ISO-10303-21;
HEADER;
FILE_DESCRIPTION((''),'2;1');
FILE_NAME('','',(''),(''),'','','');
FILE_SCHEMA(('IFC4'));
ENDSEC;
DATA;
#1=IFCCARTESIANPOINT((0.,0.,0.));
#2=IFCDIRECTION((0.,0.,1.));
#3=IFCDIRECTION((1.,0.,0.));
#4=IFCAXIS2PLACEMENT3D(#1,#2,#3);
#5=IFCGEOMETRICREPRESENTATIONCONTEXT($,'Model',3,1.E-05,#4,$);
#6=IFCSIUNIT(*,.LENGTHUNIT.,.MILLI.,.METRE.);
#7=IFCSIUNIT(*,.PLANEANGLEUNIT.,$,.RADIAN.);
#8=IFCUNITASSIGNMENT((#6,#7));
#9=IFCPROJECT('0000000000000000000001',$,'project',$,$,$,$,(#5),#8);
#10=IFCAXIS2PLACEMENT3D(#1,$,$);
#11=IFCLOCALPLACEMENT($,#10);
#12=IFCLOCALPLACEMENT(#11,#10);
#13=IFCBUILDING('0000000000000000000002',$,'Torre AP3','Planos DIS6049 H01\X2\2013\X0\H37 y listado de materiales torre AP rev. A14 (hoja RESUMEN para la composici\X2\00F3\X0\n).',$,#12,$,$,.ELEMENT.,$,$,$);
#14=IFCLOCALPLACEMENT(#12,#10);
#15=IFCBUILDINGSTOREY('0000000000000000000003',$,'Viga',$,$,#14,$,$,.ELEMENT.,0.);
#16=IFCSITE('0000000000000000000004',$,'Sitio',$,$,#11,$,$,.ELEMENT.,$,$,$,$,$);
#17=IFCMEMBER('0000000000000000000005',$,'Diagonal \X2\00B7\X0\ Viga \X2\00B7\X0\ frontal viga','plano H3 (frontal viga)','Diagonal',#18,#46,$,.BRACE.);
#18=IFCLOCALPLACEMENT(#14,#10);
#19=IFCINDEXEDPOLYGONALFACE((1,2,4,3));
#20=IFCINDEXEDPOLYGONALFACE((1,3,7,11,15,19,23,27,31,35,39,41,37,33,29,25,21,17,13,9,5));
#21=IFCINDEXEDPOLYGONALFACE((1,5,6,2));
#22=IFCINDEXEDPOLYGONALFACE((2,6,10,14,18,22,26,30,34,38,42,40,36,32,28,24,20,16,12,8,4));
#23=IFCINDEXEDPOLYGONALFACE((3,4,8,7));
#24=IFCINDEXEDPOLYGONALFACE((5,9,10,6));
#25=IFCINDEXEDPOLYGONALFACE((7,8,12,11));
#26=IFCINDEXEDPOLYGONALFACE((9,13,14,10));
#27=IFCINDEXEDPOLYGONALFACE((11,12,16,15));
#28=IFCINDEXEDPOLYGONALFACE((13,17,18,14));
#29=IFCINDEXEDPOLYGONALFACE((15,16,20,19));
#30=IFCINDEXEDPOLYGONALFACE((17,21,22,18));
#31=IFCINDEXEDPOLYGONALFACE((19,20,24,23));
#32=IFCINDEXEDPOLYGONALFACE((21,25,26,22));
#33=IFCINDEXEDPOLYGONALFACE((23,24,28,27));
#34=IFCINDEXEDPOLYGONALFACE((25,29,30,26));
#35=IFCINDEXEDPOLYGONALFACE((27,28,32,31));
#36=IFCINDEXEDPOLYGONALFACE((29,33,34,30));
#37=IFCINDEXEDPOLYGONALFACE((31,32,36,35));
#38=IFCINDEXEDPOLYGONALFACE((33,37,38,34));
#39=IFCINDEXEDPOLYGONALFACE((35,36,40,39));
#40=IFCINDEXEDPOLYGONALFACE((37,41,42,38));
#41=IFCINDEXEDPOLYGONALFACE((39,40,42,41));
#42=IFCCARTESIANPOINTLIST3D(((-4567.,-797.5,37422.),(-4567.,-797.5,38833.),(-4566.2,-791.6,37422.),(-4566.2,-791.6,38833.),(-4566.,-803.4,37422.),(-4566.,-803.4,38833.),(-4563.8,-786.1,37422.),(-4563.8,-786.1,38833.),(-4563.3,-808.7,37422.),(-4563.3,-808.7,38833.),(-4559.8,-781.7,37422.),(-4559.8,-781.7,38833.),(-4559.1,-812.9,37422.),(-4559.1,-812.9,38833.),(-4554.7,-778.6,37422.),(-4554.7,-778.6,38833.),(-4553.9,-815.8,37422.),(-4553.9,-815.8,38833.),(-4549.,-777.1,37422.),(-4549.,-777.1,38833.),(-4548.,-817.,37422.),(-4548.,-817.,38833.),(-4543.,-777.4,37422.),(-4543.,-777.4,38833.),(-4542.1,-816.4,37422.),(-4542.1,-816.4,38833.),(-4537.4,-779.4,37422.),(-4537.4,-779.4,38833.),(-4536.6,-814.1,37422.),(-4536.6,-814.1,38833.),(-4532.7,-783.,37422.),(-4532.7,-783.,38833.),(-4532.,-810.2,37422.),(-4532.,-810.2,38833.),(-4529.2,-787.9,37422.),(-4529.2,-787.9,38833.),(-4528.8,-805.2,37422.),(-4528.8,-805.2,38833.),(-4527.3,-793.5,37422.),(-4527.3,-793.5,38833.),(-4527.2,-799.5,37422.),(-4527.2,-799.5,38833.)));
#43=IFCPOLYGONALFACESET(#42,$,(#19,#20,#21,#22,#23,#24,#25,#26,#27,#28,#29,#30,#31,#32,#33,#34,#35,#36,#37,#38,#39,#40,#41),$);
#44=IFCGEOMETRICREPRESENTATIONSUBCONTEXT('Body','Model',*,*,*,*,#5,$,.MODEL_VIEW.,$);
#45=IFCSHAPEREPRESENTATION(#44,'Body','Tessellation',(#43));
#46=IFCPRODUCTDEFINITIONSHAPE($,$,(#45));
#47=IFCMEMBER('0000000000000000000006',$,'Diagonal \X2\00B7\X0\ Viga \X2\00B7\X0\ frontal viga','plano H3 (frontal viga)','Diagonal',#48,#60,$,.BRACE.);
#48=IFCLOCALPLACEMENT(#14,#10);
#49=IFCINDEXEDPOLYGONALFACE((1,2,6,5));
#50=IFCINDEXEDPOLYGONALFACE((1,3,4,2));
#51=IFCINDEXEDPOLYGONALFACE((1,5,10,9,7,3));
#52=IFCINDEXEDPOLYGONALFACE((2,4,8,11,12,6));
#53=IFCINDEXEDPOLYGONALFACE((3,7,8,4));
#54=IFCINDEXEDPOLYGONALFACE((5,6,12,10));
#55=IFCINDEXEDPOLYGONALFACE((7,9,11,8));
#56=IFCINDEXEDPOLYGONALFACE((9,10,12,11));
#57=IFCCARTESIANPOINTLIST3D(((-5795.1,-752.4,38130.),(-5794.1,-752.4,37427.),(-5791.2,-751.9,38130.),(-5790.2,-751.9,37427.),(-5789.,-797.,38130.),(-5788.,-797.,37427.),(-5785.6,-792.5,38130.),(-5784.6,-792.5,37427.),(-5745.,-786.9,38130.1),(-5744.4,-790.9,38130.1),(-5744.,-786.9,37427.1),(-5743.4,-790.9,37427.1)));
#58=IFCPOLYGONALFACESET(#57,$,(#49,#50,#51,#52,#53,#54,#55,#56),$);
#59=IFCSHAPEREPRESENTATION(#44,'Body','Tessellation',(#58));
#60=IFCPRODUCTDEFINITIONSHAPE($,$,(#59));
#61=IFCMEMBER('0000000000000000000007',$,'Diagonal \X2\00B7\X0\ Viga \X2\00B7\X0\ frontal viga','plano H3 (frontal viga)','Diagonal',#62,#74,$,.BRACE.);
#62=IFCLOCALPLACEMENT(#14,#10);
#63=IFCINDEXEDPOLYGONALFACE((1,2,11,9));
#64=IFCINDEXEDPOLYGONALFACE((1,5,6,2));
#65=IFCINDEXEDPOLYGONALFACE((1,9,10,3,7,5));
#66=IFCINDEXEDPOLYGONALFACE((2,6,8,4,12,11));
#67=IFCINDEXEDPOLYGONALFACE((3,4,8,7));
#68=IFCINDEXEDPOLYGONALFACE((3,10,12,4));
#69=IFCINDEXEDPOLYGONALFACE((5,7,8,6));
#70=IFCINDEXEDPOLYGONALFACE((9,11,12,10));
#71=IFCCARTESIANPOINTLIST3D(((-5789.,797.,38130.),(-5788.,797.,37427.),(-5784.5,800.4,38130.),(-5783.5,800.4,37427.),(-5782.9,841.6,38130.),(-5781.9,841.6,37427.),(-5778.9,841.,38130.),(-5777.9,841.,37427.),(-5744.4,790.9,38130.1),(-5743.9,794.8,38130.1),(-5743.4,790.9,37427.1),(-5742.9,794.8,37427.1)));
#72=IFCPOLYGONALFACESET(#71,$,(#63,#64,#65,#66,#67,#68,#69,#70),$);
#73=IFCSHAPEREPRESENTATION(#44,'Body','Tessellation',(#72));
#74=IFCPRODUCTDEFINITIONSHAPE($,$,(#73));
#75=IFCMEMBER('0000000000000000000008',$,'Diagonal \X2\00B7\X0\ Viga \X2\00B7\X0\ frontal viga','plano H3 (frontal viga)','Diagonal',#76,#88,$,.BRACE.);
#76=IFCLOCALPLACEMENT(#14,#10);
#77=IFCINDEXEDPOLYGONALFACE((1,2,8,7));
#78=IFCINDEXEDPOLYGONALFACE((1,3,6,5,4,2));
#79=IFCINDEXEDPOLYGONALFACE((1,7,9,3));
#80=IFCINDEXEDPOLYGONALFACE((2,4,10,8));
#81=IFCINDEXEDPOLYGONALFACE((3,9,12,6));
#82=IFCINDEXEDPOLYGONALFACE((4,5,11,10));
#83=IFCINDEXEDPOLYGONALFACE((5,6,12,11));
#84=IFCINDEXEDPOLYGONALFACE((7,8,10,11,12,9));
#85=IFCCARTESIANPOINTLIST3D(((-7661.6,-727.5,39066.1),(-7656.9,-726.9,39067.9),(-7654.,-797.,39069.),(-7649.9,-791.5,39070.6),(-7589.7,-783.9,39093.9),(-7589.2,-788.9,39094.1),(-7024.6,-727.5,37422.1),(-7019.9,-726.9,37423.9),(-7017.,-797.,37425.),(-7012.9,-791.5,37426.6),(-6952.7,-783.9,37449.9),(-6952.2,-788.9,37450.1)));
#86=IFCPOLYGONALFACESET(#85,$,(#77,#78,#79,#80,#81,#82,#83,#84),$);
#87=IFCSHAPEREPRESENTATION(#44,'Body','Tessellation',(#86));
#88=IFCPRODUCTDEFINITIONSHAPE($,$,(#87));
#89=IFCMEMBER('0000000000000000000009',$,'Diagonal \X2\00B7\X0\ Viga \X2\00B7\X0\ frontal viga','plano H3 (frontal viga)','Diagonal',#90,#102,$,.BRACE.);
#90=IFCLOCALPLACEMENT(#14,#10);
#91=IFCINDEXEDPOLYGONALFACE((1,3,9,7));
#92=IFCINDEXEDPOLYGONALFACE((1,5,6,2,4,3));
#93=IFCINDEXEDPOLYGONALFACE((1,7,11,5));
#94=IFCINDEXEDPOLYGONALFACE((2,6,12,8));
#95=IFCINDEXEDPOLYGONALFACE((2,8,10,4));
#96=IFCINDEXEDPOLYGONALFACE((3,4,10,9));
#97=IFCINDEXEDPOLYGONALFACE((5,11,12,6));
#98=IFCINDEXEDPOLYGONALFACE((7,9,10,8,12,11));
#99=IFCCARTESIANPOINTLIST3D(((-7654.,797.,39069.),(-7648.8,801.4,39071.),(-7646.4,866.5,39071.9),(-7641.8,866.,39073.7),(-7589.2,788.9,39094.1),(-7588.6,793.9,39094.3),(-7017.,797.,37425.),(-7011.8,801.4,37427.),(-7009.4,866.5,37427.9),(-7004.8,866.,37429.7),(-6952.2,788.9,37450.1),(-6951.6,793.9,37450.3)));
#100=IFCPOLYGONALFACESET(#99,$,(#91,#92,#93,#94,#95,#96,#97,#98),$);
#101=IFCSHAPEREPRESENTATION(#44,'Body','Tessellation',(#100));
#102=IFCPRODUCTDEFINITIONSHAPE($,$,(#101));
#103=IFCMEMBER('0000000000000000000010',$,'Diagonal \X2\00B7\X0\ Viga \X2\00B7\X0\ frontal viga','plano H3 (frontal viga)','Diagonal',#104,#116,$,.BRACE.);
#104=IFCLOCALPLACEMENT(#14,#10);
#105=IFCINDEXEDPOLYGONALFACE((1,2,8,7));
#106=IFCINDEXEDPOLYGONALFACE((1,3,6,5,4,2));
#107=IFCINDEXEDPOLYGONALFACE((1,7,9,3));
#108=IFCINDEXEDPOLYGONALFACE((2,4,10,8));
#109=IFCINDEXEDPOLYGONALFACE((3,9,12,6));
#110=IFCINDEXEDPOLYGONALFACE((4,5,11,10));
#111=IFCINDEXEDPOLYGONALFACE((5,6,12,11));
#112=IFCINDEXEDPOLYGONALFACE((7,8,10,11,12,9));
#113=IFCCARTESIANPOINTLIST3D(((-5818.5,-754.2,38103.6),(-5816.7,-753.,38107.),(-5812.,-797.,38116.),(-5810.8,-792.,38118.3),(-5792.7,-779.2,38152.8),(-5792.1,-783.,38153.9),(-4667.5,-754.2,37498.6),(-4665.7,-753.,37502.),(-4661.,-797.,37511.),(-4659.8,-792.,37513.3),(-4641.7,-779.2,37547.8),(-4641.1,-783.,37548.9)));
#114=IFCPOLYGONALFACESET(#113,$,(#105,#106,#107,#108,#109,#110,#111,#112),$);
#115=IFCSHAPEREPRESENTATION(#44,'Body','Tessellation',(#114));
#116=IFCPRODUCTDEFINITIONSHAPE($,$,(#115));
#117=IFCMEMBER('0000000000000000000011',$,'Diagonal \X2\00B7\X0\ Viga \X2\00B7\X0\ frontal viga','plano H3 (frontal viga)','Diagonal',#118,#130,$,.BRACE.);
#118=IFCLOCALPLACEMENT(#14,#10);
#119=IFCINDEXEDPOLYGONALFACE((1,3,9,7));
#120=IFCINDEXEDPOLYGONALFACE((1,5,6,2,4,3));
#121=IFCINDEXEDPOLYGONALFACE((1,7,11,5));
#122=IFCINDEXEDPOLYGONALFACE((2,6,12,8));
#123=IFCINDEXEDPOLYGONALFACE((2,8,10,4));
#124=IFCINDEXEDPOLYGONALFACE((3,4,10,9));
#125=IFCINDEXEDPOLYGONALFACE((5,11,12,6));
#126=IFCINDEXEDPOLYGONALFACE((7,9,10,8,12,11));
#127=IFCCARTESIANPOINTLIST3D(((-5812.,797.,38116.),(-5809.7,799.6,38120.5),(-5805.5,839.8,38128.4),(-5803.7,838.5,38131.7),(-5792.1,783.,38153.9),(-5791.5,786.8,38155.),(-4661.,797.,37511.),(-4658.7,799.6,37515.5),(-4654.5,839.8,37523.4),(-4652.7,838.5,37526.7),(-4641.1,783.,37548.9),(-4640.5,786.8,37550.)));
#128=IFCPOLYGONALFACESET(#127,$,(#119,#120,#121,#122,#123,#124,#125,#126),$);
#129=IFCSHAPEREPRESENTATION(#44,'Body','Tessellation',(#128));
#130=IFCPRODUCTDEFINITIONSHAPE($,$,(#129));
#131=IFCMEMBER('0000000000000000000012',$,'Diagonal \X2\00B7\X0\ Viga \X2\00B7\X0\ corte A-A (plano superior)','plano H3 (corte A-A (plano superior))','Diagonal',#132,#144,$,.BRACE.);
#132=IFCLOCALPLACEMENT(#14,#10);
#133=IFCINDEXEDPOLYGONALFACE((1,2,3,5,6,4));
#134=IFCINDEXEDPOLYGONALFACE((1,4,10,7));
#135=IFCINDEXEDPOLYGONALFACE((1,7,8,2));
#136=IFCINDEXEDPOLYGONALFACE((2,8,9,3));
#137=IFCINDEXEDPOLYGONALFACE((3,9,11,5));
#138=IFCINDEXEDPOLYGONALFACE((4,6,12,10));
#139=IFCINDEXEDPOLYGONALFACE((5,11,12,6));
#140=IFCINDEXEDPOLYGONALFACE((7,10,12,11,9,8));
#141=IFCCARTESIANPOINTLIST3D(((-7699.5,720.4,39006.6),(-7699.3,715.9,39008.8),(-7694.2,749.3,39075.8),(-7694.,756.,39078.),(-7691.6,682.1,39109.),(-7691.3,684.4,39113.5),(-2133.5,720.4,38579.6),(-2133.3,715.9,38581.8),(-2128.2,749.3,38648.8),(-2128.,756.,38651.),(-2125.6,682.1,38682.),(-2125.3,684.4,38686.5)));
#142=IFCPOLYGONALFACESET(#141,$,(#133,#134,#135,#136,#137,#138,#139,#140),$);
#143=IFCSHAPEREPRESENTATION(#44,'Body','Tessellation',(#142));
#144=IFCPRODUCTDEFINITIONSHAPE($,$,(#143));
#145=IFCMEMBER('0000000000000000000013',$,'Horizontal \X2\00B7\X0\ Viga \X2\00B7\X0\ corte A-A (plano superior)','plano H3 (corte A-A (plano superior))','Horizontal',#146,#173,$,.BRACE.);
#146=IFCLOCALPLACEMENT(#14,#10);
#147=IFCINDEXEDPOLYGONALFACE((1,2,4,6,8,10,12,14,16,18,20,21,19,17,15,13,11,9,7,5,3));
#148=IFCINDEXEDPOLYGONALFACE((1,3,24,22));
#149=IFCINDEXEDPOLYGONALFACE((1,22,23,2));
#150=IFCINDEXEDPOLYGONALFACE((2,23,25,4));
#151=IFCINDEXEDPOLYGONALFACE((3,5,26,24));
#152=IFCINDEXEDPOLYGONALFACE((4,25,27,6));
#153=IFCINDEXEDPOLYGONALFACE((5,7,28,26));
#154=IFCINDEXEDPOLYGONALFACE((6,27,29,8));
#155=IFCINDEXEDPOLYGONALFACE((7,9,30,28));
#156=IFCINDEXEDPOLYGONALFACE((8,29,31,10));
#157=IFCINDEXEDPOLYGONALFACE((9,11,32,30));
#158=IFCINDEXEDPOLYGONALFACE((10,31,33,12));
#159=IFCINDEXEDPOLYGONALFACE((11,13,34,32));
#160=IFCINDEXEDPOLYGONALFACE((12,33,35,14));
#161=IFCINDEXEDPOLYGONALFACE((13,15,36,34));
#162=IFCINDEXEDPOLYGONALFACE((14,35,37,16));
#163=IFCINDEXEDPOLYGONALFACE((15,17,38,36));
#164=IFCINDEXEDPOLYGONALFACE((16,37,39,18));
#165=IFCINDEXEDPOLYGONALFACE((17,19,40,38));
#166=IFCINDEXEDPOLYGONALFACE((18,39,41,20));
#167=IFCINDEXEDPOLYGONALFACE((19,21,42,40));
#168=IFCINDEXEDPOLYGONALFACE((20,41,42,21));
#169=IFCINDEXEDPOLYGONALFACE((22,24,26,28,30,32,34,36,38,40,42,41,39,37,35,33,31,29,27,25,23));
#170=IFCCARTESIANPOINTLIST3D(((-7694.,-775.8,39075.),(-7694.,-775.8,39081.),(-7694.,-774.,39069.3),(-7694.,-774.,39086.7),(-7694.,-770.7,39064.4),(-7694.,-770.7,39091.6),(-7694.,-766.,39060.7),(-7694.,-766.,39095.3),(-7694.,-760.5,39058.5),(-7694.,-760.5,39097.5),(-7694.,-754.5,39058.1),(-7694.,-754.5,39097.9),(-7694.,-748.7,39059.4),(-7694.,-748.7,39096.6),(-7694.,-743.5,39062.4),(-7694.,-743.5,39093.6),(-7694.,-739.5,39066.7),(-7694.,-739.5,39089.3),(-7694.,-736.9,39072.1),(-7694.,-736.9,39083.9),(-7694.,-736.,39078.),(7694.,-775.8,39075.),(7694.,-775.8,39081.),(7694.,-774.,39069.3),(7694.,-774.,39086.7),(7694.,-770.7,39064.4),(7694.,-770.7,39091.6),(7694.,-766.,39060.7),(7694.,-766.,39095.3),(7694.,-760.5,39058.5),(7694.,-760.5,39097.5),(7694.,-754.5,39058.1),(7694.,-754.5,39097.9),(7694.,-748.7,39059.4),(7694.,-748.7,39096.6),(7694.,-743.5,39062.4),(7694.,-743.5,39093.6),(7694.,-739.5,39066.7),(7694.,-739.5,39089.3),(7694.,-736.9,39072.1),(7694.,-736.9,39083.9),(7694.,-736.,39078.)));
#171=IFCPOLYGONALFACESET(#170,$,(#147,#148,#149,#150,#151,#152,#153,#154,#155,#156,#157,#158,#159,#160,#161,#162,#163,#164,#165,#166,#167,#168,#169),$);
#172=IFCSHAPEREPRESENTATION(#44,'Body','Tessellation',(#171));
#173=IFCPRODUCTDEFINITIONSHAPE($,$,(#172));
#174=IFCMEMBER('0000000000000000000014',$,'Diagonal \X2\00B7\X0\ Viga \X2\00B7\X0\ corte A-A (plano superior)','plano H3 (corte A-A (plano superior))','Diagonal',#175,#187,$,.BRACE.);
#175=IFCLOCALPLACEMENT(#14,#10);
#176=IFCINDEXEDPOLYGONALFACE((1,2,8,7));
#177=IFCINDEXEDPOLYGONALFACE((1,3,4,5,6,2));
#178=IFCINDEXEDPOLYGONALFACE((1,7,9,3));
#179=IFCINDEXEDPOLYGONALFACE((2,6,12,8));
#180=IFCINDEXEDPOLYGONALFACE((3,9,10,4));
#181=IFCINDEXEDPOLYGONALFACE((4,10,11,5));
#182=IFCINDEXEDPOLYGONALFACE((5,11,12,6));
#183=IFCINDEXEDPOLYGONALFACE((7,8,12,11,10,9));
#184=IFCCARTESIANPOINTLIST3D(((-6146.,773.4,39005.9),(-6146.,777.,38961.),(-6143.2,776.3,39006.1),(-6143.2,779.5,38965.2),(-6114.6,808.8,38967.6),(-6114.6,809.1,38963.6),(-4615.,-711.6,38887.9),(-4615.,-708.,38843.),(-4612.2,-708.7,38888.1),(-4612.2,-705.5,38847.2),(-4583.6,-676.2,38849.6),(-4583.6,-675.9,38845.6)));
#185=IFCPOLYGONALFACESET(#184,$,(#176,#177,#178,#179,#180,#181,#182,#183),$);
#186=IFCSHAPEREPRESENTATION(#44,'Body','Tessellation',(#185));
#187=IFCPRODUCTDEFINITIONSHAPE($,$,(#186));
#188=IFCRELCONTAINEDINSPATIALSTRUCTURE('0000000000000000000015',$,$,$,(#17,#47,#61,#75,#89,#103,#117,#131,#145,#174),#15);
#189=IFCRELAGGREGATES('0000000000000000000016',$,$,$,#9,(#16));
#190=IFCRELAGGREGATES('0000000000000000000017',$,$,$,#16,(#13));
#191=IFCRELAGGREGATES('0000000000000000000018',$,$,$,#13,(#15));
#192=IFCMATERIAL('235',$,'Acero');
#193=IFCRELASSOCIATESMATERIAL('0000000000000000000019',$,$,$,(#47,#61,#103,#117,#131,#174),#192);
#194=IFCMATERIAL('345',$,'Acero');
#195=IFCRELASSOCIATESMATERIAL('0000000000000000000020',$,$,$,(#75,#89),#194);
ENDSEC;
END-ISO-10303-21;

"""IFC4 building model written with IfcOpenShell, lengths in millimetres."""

from ifc_helpers import new_model, si_unit, frame, frame_2d, origin, origin_with_axes, place, context, subcontext, project, spatial, circle, l_section, extrude, material, element, save


model = new_model("IFC4")

# Units and contexts
model_context = context("Model", 3, precision=1e-05, world=origin_with_axes())
body_context = subcontext(model_context, "Body", "Model", "MODEL_VIEW")
ifc_project = project(units=[si_unit("LENGTHUNIT", "METRE", prefix="MILLI"), si_unit("PLANEANGLEUNIT", "RADIAN")], contexts=[model_context])

# Site, building, storey
site_placement = place(None, origin())
site = spatial("IfcSite", under=ifc_project, at=site_placement, Name="Sitio", CompositionType="ELEMENT")
building_placement = place(site_placement, origin())
building = spatial("IfcBuilding", under=site, at=building_placement, Name="Torre AP3", Description="Planos DIS6049 H01–H37 y listado de materiales torre AP rev. A14 (hoja RESUMEN para la composición).", CompositionType="ELEMENT")
storey_placement = place(building_placement, origin())
storey = spatial("IfcBuildingStorey", under=building, at=storey_placement, Name="Viga", CompositionType="ELEMENT", Elevation=0.0)

# Members
ifc_material_1 = material(Name="345", Category="Acero")
member_1_placement = place(storey_placement, frame((-4547.0, -797.0, 37422.0), z_axis=(0.0, 0.0, 1.0), x_axis=(0.984984, 0.172648, 0.0)))
element("IfcMember", 1, at=member_1_placement, inside=storey, Name="Diagonal · Viga · frontal viga", Description="plano H3 (frontal viga)", ObjectType="Diagonal", PredefinedType="BRACE", context=body_context, shape_type="SweptSolid", body=[
    extrude(circle(Radius=20.0), None, (0.0, 0.0, 1.0), 1411.0),
])
ifc_material_2 = material(Name="235", Category="Acero")
for number, where, z_axis, x_axis, name in (
    (2, (-5788.0, -797.0, 37427.0), (-0.001422, 0.0, 0.999999), (0.990653, 0.1364, 0.001409), "Diagonal · Viga · frontal viga"),
    (3, (-5788.0, 797.0, 37427.0), (-0.001422, 0.0, 0.999999), (0.990653, -0.1364, 0.001409), "Diagonal · Viga · frontal viga"),
):
    element("IfcMember", number, at=place(storey_placement, frame(where, z_axis=z_axis, x_axis=x_axis)), inside=storey, material=ifc_material_2, Name=name, Description="plano H3 (frontal viga)", ObjectType="Diagonal", PredefinedType="BRACE", context=body_context, shape_type="SweptSolid", body=[
        extrude(l_section(Depth=45.0, Width=45.0, Thickness=4.0, at=frame_2d((22.5, 22.5))), None, (0.0, 0.0, 1.0), 703.0),
    ])
for number, where, z_axis, x_axis, name in (
    (4, (-7017.0, -797.0, 37425.0), (-0.361296, 0.0, 0.932451), (0.926185, 0.115738, 0.358868), "Diagonal · Viga · frontal viga"),
    (5, (-7017.0, 797.0, 37425.0), (-0.361296, 0.0, 0.932451), (0.926185, -0.115738, 0.358868), "Diagonal · Viga · frontal viga"),
):
    element("IfcMember", number, at=place(storey_placement, frame(where, z_axis=z_axis, x_axis=x_axis)), inside=storey, material=ifc_material_1, Name=name, Description="plano H3 (frontal viga)", ObjectType="Diagonal", PredefinedType="BRACE", context=body_context, shape_type="SweptSolid", body=[
        extrude(l_section(Depth=70.0, Width=70.0, Thickness=5.0, at=frame_2d((35.0, 35.0))), None, (0.0, 0.0, 1.0), 1763.1),
    ])
for number, where, z_axis, x_axis, name in (
    (6, (-4661.0, -797.0, 37511.0), (-0.885168, 0.0, 0.465271), (0.442212, 0.310911, 0.841299), "Diagonal · Viga · frontal viga"),
    (7, (-4661.0, 797.0, 37511.0), (-0.885168, 0.0, 0.465271), (0.442212, -0.310911, 0.841299), "Diagonal · Viga · frontal viga"),
):
    element("IfcMember", number, at=place(storey_placement, frame(where, z_axis=z_axis, x_axis=x_axis)), inside=storey, material=ifc_material_2, Name=name, Description="plano H3 (frontal viga)", ObjectType="Diagonal", PredefinedType="BRACE", context=body_context, shape_type="SweptSolid", body=[
        extrude(l_section(Depth=45.0, Width=45.0, Thickness=4.0, at=frame_2d((22.5, 22.5))), None, (0.0, 0.0, 1.0), 1300.3),
    ])
member_2_placement = place(storey_placement, frame((-7694.0, 756.0, 39078.0), z_axis=(0.99707, 0.0, -0.076491), x_axis=(0.034037, -0.895539, 0.443679)))
element("IfcMember", 8, at=member_2_placement, inside=storey, material=ifc_material_2, Name="Diagonal · Viga · corte A-A (plano superior)", Description="plano H3 (corte A-A (plano superior))", ObjectType="Diagonal", PredefinedType="BRACE", context=body_context, shape_type="SweptSolid", body=[
    extrude(l_section(Depth=80.0, Width=80.0, Thickness=5.0, at=frame_2d((40.0, 40.0))), None, (0.0, 0.0, 1.0), 5582.4),
])
member_3_placement = place(storey_placement, frame((-7694.0, -756.0, 39078.0), z_axis=(1.0, 0.0, 0.0), x_axis=(0.0, 1.0, 0.0)))
element("IfcMember", 9, at=member_3_placement, inside=storey, Name="Horizontal · Viga · corte A-A (plano superior)", Description="plano H3 (corte A-A (plano superior))", ObjectType="Horizontal", PredefinedType="BRACE", context=body_context, shape_type="SweptSolid", body=[
    extrude(circle(Radius=20.0), None, (0.0, 0.0, 1.0), 15388.0),
])
member_4_placement = place(storey_placement, frame((-6146.0, 777.0, 38961.0), z_axis=(0.716712, -0.695178, -0.05524), x_axis=(0.697369, 0.714402, 0.057503)))
element("IfcMember", 10, at=member_4_placement, inside=storey, material=ifc_material_2, Name="Diagonal · Viga · corte A-A (plano superior)", Description="plano H3 (corte A-A (plano superior))", ObjectType="Diagonal", PredefinedType="BRACE", context=body_context, shape_type="SweptSolid", body=[
    extrude(l_section(Depth=45.0, Width=45.0, Thickness=4.0, at=frame_2d((22.5, 22.5))), None, (0.0, 0.0, 1.0), 2136.1),
])

save(model, "model.ifc")
